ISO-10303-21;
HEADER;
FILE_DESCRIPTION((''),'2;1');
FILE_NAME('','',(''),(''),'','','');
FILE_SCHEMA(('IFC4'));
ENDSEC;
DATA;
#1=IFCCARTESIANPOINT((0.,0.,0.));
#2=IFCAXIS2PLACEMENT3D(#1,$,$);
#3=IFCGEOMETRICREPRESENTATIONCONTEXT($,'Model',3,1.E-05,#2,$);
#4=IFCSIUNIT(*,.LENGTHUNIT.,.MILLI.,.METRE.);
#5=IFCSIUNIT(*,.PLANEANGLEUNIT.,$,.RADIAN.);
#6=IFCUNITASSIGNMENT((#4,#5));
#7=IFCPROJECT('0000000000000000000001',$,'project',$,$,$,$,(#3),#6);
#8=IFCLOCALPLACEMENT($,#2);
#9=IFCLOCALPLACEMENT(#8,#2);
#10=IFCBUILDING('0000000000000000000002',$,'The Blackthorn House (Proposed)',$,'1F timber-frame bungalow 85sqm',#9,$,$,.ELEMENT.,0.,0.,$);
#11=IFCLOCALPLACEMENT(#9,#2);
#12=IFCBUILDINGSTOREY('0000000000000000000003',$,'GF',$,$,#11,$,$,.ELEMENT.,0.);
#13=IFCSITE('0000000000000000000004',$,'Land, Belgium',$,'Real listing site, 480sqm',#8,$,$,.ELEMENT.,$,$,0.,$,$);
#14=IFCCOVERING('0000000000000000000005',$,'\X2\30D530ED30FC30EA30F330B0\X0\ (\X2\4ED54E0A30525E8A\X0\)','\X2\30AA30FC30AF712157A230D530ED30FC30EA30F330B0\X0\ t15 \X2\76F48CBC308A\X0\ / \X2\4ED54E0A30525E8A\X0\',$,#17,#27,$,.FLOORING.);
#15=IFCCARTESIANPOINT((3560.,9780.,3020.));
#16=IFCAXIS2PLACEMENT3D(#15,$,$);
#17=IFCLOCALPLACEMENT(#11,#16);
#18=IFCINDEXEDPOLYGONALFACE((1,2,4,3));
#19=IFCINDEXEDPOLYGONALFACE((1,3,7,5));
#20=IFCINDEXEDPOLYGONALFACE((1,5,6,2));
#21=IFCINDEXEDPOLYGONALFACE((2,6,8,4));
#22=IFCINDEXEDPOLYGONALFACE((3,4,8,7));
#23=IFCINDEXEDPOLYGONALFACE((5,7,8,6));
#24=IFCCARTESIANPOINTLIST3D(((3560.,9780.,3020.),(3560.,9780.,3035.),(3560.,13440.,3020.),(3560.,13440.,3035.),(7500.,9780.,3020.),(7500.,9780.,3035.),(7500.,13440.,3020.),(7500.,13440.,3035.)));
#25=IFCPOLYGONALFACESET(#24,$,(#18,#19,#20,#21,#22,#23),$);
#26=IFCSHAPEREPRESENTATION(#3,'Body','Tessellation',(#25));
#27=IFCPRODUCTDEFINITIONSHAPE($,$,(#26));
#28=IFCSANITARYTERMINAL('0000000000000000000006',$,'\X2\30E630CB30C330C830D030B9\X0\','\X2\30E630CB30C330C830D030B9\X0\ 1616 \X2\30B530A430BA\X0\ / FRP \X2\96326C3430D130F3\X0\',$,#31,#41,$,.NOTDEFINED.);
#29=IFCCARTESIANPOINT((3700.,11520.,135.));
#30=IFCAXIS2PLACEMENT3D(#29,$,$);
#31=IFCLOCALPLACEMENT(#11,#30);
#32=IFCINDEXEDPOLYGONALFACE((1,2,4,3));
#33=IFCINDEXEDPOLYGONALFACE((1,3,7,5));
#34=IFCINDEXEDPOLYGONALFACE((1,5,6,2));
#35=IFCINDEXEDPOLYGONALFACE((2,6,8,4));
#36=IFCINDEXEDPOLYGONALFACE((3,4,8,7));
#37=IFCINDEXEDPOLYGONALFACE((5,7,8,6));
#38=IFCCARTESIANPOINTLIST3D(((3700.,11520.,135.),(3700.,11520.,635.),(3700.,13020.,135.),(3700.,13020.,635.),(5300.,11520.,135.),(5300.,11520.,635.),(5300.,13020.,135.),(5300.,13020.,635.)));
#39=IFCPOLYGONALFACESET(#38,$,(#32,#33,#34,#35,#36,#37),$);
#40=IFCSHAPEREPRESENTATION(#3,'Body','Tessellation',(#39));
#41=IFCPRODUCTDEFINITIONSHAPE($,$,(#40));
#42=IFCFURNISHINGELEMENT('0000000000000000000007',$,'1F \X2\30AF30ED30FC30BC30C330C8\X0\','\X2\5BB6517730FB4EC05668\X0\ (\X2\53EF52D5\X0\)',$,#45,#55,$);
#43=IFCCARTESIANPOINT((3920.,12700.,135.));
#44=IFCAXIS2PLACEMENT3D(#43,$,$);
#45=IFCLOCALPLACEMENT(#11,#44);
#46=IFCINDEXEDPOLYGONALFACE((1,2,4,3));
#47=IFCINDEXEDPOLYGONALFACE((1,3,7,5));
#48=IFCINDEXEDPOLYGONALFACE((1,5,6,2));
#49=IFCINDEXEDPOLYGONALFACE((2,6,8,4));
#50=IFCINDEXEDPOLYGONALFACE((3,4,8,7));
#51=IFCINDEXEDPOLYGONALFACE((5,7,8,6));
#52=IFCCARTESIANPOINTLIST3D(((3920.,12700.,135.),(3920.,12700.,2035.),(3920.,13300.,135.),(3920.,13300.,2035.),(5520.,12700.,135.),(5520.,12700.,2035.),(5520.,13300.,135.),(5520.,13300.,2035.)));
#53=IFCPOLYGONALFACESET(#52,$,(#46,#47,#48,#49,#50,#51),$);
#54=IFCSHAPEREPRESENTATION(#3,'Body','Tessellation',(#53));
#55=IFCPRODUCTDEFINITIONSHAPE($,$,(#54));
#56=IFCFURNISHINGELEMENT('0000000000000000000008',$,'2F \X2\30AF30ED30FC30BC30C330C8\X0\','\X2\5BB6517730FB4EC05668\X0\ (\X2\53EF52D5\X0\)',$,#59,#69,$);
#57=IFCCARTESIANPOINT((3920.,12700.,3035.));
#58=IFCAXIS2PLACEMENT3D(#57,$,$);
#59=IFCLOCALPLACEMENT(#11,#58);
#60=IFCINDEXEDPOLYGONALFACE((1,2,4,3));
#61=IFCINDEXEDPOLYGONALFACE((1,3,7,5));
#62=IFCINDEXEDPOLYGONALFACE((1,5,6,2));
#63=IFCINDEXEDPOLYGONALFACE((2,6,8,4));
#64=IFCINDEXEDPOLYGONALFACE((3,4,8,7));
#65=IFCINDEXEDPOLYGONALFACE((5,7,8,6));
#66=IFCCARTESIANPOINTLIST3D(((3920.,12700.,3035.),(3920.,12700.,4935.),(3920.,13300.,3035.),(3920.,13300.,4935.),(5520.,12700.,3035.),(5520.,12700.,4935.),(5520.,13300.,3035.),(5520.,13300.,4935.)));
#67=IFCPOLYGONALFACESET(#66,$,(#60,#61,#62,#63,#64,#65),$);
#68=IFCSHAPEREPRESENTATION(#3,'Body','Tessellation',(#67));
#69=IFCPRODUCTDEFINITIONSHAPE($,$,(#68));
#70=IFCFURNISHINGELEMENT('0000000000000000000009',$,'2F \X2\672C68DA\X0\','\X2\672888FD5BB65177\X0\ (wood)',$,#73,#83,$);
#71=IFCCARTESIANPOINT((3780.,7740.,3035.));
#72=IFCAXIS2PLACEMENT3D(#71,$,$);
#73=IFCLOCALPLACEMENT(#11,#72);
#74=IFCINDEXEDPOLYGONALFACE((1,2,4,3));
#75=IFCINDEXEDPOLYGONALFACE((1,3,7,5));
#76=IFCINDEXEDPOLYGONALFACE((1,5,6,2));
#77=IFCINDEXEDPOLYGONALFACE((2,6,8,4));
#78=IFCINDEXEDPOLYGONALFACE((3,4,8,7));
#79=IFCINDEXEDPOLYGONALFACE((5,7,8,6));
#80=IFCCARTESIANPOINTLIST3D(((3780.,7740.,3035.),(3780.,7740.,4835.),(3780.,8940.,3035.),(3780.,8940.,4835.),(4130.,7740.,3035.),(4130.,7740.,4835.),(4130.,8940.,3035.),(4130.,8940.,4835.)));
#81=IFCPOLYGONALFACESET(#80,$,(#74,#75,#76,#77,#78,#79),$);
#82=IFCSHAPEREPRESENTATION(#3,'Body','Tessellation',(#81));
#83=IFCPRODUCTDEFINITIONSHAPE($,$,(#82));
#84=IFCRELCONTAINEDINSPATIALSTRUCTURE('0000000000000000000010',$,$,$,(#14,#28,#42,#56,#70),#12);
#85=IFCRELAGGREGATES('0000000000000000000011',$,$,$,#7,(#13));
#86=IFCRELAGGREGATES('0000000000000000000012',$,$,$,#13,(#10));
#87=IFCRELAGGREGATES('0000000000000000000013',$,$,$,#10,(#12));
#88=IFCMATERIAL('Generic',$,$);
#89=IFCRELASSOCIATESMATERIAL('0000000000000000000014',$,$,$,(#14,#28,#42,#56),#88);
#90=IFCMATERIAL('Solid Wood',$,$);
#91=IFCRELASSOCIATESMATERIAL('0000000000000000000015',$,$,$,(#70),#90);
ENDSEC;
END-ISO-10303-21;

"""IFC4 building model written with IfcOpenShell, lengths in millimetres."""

from ifc_helpers import new_model, si_unit, frame, frame_2d, origin, place, context, project, spatial, rectangle, extrude, material, element, save


model = new_model("IFC4")

# Units and contexts
model_context = context("Model", 3, precision=1e-05, world=origin())
ifc_project = project(units=[si_unit("LENGTHUNIT", "METRE", prefix="MILLI"), si_unit("PLANEANGLEUNIT", "RADIAN")], contexts=[model_context])

# Site, building, storey
site_placement = place(None, origin())
site = spatial("IfcSite", under=ifc_project, at=site_placement, Name="Land, Belgium", ObjectType="Real listing site, 480sqm", CompositionType="ELEMENT", RefElevation=0.0)
building_placement = place(site_placement, origin())
building = spatial("IfcBuilding", under=site, at=building_placement, Name="The Blackthorn House (Proposed)", ObjectType="1F timber-frame bungalow 85sqm", CompositionType="ELEMENT", ElevationOfRefHeight=0.0, ElevationOfTerrain=0.0)
storey_placement = place(building_placement, origin())
storey = spatial("IfcBuildingStorey", under=building, at=storey_placement, Name="GF", CompositionType="ELEMENT", Elevation=0.0)

# Shared definitions
ifc_material_1 = material(Name="Solid Wood")

# Covering
ifc_material_2 = material(Name="Generic")
covering_1_placement = place(storey_placement, frame((3560.0, 9780.0, 3020.0)))
element("IfcCovering", 1, at=covering_1_placement, inside=storey, material=ifc_material_2, Name="フローリング (仕上げ床)", Description="オーク無垢フローリング t15 直貼り / 仕上げ床", PredefinedType="FLOORING", context=model_context, shape_type="SweptSolid", body=[
    extrude(rectangle(XDim=3940.0, YDim=3660.0, at=frame_2d((1970.0, 1830.0))), frame((3560.0, 9780.0, 3020.0)), (0.0, 0.0, 1.0), 15.0),
])

# Sanitary terminal
sanitary_terminal_placement = place(storey_placement, frame((3700.0, 11520.0, 135.0)))
element("IfcSanitaryTerminal", 2, at=sanitary_terminal_placement, inside=storey, material=ifc_material_2, Name="ユニットバス", Description="ユニットバス 1616 サイズ / FRP 防水パン", PredefinedType="NOTDEFINED", context=model_context, shape_type="SweptSolid", body=[
    extrude(rectangle(XDim=1600.0, YDim=1500.0, at=frame_2d((800.0, 750.0))), frame((3700.0, 11520.0, 135.0)), (0.0, 0.0, 1.0), 500.0),
])

# Furnishing elements
furnishing_1_placement = place(storey_placement, frame((3920.0, 12700.0, 135.0)))
element("IfcFurnishingElement", 3, at=furnishing_1_placement, inside=storey, material=ifc_material_2, Name="1F クローゼット", Description="家具・什器 (可動)", context=model_context, shape_type="SweptSolid", body=[
    extrude(rectangle(XDim=1600.0, YDim=600.0, at=frame_2d((800.0, 300.0))), frame((3920.0, 12700.0, 135.0)), (0.0, 0.0, 1.0), 1900.0),
])
furnishing_2_placement = place(storey_placement, frame((3920.0, 12700.0, 3035.0)))
element("IfcFurnishingElement", 4, at=furnishing_2_placement, inside=storey, material=ifc_material_2, Name="2F クローゼット", Description="家具・什器 (可動)", context=model_context, shape_type="SweptSolid", body=[
    extrude(rectangle(XDim=1600.0, YDim=600.0, at=frame_2d((800.0, 300.0))), frame((3920.0, 12700.0, 3035.0)), (0.0, 0.0, 1.0), 1900.0),
])
furnishing_3_placement = place(storey_placement, frame((3780.0, 7740.0, 3035.0)))
element("IfcFurnishingElement", 5, at=furnishing_3_placement, inside=storey, material=ifc_material_1, Name="2F 本棚", Description="木製家具 (wood)", context=model_context, shape_type="SweptSolid", body=[
    extrude(rectangle(XDim=350.0, YDim=1200.0, at=frame_2d((175.0, 600.0))), frame((3780.0, 7740.0, 3035.0)), (0.0, 0.0, 1.0), 1800.0),
])

save(model, "model.ifc")
